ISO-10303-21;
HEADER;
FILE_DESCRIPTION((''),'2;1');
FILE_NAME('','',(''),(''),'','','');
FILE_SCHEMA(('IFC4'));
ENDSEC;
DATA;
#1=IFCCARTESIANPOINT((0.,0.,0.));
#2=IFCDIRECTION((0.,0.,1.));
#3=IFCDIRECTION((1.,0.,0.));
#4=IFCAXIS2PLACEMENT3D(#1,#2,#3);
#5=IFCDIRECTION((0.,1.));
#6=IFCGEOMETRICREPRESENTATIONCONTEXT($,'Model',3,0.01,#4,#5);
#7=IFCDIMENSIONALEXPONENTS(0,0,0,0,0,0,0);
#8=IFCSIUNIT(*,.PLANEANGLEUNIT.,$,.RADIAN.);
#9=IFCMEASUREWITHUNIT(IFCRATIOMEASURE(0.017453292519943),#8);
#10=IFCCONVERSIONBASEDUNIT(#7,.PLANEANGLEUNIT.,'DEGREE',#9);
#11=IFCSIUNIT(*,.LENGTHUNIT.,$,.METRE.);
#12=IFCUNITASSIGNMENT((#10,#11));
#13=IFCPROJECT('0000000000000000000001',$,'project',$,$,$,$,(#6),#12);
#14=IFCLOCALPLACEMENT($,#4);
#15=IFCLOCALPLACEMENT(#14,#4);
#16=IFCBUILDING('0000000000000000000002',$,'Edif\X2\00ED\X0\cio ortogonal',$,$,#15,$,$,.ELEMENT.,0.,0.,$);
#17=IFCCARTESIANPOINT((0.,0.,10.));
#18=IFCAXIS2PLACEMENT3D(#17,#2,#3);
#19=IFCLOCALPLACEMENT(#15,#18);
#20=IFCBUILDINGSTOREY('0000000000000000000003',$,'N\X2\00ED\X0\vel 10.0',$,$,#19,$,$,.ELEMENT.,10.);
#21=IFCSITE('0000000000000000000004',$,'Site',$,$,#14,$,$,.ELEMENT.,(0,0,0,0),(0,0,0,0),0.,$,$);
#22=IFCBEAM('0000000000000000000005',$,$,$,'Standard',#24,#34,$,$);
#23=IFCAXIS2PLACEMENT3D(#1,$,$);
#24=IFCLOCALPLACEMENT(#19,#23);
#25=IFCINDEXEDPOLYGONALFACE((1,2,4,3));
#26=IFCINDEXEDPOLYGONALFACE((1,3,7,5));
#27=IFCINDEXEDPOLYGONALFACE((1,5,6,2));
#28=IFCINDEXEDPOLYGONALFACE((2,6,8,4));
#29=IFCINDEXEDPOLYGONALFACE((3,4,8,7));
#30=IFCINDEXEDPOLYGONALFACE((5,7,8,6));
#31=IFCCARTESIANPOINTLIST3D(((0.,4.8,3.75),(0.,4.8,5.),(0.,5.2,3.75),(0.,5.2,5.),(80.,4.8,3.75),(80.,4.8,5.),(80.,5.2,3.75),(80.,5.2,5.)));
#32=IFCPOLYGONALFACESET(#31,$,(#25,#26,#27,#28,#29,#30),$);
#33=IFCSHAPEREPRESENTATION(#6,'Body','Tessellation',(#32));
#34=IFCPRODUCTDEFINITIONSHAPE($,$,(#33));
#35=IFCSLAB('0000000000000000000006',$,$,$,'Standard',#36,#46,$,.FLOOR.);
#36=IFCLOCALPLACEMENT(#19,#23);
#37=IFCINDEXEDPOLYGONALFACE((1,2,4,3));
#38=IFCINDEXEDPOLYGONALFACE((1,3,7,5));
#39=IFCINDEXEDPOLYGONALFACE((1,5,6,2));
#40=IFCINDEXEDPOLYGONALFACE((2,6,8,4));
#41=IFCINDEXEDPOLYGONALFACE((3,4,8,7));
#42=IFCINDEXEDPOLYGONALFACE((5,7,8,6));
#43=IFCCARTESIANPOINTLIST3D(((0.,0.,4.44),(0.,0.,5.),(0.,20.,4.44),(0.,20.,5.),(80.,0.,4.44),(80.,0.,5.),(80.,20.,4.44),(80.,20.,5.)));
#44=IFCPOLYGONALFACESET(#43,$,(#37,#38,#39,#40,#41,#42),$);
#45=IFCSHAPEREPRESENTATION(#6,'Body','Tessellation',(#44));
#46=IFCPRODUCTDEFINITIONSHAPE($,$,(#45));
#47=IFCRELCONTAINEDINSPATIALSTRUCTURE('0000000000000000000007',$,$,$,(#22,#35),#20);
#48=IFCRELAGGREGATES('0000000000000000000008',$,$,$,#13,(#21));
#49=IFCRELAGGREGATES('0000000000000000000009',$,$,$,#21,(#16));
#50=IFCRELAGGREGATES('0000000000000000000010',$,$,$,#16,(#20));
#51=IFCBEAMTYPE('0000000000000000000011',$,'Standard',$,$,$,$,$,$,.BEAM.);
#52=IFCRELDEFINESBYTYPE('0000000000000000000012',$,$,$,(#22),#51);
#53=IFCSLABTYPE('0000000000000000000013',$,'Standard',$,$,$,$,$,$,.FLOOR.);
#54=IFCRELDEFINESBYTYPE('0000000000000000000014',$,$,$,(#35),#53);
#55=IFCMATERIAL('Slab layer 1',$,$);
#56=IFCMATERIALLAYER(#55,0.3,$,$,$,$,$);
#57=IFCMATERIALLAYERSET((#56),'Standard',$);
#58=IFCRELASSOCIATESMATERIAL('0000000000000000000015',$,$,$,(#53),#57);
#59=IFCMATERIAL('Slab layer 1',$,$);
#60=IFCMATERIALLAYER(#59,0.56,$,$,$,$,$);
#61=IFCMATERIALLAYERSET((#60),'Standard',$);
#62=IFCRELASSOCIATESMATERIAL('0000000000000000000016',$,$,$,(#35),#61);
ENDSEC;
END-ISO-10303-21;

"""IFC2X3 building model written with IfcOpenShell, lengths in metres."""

from ifc_helpers import new_model, entity, si_unit, converted_unit, direction, frame, origin_with_axes, origin_2d, place, context, project, spatial, polyline, rectangle, outline, extrude, material, layer, layer_set, layer_usage, type_object, element, save


model = new_model("IFC2X3")

# Units and contexts
model_context = context("Model", 3, precision=0.01, world=origin_with_axes(), true_north=direction((0.0, 1.0)))
ifc_project = project(units=[converted_unit("PLANEANGLEUNIT", "DEGREE", entity("IfcRatioMeasure", 0.017453292519943), si_unit("PLANEANGLEUNIT", "RADIAN"), dimensions=[0, 0, 0, 0, 0, 0, 0]), si_unit("LENGTHUNIT", "METRE")], contexts=[model_context])

# Site, building, storey
site_placement = place(None, origin_with_axes())
site = spatial("IfcSite", under=ifc_project, at=site_placement, Name="Site", CompositionType="ELEMENT", RefLatitude=(0, 0, 0, 0), RefLongitude=(0, 0, 0, 0), RefElevation=0.0)
building_placement = place(site_placement, origin_with_axes())
building = spatial("IfcBuilding", under=site, at=building_placement, Name="Edifício ortogonal", CompositionType="ELEMENT", ElevationOfRefHeight=0.0, ElevationOfTerrain=0.0)
storey_placement = place(building_placement, frame((0.0, 0.0, 10.0), z_axis=(0.0, 0.0, 1.0), x_axis=(1.0, 0.0, 0.0)))
storey = spatial("IfcBuildingStorey", under=building, at=storey_placement, Name="Nível 10.0", CompositionType="ELEMENT", Elevation=10.0)

# Beam
beam_type = type_object("IfcBeamType", Name="Standard", PredefinedType="BEAM")
beam_placement = place(site_placement, frame((0.0, 5.0, 15.0), z_axis=(0.0, 0.0, 1.0), x_axis=(1.0, 0.0, 0.0)))
element("IfcBeam", 1, at=beam_placement, inside=storey, type_object=beam_type, ObjectType="Standard", context=model_context, shape_type="SweptSolid", body=[
    extrude(rectangle(XDim=0.4, YDim=1.25, at=origin_2d()), frame((0.0, 0.0, -0.625), z_axis=(1.0, 0.0, 0.0), x_axis=(0.0, 1.0, 0.0)), (0.0, 0.0, 1.0), 80.0),
])

# Slab
ifc_material_1 = material(Name="Slab layer 1")
ifc_layer_1 = layer(ifc_material_1, 0.56)
ifc_layer_set_1 = layer_set([ifc_layer_1], Name="Standard")
ifc_layer_usage = layer_usage(ifc_layer_set_1, "AXIS3", "POSITIVE", 0.0)
ifc_material_2 = material(Name="Slab layer 1")
ifc_layer_2 = layer(ifc_material_2, 0.3)
ifc_layer_set_2 = layer_set([ifc_layer_2], Name="Standard")
slab_type = type_object("IfcSlabType", Name="Standard", PredefinedType="FLOOR", material=ifc_layer_set_2)
slab_placement = place(site_placement, frame((0.0, 0.0, 15.0), z_axis=(0.0, 0.0, 1.0), x_axis=(1.0, 0.0, 0.0)))
element("IfcSlab", 2, at=slab_placement, inside=storey, type_object=slab_type, material=ifc_layer_usage, ObjectType="Standard", PredefinedType="FLOOR", context=model_context, shape_type="SweptSolid", body=[
    extrude(outline(polyline([(0.0, 0.0), (80.0, 0.0), (80.0, 20.0), (0.0, 20.0), (0.0, 0.0)])), frame((0.0, 0.0, -0.56), z_axis=(0.0, 0.0, 1.0), x_axis=(1.0, 0.0, 0.0)), (0.0, 0.0, 1.0), 0.56),
])

save(model, "model.ifc")
